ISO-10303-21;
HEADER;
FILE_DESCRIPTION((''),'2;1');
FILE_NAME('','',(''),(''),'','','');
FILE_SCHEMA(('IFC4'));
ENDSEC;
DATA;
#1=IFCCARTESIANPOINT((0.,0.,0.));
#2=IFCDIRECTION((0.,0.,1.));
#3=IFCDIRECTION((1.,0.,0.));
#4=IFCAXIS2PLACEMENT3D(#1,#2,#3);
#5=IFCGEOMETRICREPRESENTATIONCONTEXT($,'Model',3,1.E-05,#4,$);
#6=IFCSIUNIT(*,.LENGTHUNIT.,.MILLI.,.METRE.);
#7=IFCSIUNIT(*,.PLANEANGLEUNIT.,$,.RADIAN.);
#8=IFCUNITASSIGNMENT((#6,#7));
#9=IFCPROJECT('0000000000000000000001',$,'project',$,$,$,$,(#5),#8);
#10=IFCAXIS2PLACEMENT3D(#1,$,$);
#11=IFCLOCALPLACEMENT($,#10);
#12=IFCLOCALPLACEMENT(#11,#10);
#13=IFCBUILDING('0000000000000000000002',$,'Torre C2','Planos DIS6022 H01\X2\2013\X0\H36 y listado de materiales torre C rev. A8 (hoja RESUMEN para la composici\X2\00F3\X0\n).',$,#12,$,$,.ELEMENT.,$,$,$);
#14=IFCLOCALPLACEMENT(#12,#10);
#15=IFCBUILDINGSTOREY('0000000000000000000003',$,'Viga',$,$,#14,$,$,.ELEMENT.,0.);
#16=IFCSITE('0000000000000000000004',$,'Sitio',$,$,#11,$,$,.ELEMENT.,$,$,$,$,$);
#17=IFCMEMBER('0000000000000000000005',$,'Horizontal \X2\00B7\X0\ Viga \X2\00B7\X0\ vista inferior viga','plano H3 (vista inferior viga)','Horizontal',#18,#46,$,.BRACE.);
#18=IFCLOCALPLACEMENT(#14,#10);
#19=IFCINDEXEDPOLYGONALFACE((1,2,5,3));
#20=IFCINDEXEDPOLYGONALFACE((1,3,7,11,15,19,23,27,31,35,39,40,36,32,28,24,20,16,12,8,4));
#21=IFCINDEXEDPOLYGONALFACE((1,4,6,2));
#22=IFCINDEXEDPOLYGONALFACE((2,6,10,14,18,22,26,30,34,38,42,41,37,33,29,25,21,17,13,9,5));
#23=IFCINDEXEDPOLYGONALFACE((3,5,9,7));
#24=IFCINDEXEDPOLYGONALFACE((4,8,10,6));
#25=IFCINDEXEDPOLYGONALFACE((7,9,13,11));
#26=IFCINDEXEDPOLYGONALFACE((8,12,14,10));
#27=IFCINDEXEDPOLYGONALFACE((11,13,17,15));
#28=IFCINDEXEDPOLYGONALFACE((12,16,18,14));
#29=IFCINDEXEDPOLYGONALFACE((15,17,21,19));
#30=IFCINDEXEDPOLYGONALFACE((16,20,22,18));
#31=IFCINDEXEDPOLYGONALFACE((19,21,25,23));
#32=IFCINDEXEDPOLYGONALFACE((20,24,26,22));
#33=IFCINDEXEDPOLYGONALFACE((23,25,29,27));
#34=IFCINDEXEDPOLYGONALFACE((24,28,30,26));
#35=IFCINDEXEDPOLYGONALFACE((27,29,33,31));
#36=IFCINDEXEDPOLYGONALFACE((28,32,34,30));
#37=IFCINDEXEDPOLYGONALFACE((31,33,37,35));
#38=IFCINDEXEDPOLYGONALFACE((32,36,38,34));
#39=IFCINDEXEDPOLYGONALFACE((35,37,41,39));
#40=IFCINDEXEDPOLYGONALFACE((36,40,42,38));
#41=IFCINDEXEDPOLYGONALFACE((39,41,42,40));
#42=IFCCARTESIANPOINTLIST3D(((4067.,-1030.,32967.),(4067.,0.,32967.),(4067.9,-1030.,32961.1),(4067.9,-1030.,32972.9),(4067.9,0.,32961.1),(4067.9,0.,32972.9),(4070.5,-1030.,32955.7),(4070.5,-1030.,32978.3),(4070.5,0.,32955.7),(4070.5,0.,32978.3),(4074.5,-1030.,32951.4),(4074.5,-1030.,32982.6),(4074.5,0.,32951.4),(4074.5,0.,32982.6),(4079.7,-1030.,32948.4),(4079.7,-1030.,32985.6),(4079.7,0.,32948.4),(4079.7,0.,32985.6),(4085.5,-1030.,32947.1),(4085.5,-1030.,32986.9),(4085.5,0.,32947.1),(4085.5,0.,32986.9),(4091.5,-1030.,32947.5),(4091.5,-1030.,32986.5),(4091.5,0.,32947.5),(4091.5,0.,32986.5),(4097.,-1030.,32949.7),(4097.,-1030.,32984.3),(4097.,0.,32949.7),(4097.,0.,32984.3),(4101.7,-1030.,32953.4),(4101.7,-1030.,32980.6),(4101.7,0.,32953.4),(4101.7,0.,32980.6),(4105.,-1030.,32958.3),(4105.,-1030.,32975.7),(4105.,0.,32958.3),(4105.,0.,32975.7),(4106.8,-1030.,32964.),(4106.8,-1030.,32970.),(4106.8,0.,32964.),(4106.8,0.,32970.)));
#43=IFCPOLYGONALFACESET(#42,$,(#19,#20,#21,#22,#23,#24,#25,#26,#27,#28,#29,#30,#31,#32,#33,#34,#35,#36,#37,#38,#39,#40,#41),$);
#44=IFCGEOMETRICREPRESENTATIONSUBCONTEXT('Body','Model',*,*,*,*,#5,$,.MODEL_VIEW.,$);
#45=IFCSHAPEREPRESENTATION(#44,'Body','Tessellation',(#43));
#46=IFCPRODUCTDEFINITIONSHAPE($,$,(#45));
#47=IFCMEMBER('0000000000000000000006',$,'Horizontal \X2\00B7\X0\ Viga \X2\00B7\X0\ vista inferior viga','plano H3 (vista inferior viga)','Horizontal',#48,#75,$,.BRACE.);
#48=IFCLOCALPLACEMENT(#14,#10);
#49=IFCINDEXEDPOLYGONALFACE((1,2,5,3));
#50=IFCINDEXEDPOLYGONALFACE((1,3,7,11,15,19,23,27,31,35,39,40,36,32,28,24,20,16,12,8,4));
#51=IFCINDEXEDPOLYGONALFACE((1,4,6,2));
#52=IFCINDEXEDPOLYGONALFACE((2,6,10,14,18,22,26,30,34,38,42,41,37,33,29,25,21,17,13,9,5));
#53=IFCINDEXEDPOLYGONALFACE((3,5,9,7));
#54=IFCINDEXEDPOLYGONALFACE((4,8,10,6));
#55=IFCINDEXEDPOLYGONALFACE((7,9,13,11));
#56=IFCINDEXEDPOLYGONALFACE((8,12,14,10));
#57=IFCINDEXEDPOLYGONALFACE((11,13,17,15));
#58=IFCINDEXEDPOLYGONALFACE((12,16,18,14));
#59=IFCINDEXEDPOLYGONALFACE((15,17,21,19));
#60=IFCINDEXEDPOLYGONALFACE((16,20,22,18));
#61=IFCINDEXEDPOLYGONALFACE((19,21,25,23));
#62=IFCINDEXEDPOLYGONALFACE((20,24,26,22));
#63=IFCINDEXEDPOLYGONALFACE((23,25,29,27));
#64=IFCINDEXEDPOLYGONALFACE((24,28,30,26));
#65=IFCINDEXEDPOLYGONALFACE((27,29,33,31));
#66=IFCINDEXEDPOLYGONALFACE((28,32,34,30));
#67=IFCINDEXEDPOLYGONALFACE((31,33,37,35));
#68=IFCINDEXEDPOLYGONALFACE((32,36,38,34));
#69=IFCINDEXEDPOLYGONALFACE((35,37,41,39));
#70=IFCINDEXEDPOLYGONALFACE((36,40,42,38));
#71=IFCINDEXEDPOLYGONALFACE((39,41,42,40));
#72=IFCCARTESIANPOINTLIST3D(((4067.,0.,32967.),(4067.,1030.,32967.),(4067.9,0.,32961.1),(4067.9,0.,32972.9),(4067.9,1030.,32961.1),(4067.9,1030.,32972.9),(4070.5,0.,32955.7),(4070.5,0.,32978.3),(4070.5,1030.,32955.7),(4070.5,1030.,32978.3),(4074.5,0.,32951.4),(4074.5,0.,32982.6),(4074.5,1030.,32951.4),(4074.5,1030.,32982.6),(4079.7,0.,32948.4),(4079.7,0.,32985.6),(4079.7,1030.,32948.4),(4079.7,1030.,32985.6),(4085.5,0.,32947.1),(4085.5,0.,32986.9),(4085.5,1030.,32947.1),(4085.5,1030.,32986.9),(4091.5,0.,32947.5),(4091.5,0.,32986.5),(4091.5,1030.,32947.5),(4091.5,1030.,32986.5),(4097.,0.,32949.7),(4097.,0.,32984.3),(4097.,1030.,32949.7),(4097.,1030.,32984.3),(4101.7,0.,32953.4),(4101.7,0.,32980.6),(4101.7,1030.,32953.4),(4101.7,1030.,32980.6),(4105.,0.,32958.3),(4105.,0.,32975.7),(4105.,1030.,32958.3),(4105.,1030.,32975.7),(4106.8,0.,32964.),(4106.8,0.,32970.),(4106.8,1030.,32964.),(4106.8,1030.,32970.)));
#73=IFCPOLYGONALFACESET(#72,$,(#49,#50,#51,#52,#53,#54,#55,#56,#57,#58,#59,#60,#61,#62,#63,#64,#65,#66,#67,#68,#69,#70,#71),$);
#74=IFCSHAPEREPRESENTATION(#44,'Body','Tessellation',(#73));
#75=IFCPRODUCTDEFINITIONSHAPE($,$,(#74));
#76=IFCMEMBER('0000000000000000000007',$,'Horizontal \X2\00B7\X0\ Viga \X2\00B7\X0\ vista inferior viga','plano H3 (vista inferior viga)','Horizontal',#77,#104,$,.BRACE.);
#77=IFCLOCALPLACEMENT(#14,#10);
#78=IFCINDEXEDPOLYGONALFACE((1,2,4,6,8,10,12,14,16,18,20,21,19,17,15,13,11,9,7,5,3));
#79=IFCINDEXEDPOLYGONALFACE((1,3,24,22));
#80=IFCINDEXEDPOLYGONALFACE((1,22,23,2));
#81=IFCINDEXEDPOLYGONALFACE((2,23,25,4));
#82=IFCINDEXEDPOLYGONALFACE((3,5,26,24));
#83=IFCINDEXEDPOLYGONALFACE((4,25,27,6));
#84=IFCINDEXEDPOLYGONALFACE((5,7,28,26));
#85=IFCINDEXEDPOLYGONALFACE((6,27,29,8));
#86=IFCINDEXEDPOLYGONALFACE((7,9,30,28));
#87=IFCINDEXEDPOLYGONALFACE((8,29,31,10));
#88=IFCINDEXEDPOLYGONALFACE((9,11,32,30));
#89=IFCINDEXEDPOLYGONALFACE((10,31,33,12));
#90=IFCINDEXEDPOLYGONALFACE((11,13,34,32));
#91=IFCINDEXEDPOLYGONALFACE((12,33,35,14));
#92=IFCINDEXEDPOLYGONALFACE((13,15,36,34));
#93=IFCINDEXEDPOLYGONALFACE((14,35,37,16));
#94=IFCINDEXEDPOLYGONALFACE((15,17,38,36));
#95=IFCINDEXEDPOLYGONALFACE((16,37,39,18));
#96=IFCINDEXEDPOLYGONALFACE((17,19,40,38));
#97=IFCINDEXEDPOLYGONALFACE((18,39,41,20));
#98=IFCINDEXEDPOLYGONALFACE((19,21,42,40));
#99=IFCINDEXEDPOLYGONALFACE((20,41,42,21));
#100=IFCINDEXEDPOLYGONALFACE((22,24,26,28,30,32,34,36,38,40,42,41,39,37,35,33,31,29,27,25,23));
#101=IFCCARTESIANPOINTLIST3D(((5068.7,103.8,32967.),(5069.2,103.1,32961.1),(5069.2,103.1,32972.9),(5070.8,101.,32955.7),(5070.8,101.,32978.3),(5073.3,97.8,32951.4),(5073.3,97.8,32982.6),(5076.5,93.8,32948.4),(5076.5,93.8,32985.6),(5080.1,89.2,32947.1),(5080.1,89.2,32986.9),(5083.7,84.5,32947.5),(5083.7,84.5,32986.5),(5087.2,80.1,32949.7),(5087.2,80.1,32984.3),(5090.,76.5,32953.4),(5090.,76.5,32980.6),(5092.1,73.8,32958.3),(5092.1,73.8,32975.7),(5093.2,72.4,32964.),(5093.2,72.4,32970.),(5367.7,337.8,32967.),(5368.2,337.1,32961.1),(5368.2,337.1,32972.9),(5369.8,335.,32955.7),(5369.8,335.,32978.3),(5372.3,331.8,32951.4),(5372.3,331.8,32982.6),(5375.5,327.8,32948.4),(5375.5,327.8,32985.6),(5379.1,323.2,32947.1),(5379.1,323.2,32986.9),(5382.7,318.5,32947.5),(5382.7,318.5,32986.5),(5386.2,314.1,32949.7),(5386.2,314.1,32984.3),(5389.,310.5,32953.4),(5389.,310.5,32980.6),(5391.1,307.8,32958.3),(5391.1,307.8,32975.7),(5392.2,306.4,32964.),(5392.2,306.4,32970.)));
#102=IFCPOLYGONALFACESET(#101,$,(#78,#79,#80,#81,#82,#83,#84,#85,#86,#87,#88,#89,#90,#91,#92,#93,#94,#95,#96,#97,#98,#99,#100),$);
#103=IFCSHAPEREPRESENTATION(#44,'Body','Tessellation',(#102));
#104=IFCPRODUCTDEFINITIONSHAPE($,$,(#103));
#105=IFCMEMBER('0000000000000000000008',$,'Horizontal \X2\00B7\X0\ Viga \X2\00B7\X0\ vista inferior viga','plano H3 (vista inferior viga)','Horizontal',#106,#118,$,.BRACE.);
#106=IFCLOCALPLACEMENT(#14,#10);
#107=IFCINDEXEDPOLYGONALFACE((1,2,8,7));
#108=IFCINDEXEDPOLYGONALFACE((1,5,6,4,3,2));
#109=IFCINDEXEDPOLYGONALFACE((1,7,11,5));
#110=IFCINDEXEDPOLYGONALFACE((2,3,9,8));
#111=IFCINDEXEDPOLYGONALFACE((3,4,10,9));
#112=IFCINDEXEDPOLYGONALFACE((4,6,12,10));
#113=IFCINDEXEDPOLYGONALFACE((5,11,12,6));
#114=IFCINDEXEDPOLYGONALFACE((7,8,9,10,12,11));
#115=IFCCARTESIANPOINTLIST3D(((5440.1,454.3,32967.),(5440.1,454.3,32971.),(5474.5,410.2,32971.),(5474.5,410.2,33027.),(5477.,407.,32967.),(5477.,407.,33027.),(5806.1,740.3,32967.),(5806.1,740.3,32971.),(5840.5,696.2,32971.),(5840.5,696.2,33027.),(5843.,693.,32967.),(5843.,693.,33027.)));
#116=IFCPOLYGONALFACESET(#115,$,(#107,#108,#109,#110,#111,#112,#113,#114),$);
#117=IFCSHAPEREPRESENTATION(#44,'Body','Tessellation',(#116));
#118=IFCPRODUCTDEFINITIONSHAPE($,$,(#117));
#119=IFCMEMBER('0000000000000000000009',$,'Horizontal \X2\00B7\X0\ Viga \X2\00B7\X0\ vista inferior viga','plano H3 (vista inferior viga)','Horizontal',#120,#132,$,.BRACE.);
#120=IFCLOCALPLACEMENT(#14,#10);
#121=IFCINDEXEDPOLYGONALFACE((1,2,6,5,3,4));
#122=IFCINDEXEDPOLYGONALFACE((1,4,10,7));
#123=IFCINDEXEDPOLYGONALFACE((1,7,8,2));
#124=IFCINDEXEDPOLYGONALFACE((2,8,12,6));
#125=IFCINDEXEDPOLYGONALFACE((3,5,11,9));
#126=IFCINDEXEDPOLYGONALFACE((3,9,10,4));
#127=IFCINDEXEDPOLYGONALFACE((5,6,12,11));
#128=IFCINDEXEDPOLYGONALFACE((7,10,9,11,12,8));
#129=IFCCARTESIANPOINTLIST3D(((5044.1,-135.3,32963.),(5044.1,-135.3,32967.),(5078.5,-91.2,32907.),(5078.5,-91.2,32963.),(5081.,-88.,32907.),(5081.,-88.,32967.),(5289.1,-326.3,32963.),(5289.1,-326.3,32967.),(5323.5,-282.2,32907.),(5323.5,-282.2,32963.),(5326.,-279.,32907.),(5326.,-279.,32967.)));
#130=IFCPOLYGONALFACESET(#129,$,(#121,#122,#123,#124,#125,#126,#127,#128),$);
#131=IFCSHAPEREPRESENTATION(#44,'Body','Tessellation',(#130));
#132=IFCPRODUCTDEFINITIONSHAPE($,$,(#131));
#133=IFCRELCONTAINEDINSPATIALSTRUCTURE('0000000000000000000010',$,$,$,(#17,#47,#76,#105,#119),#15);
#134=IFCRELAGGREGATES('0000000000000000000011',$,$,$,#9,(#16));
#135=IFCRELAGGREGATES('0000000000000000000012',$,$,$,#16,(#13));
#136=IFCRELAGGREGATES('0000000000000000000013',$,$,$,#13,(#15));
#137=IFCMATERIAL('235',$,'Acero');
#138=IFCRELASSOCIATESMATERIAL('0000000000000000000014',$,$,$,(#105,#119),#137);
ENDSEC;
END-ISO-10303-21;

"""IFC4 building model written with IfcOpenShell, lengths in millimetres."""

from ifc_helpers import new_model, si_unit, frame, frame_2d, origin, origin_with_axes, place, context, subcontext, project, spatial, circle, l_section, extrude, material, element, save


model = new_model("IFC4")

# Units and contexts
model_context = context("Model", 3, precision=1e-05, world=origin_with_axes())
body_context = subcontext(model_context, "Body", "Model", "MODEL_VIEW")
ifc_project = project(units=[si_unit("LENGTHUNIT", "METRE", prefix="MILLI"), si_unit("PLANEANGLEUNIT", "RADIAN")], contexts=[model_context])

# Site, building, storey
site_placement = place(None, origin())
site = spatial("IfcSite", under=ifc_project, at=site_placement, Name="Sitio", CompositionType="ELEMENT")
building_placement = place(site_placement, origin())
building = spatial("IfcBuilding", under=site, at=building_placement, Name="Torre C2", Description="Planos DIS6022 H01–H36 y listado de materiales torre C rev. A8 (hoja RESUMEN para la composición).", CompositionType="ELEMENT")
storey_placement = place(building_placement, origin())
storey = spatial("IfcBuildingStorey", under=building, at=storey_placement, Name="Viga", CompositionType="ELEMENT", Elevation=0.0)

# Members
ifc_material_1 = material(Name="235", Category="Acero")
for number, where, z_axis, x_axis, name in (
    (1, (4087.0, 0.0, 32967.0), (0.0, -1.0, 0.0), (-1.0, 0.0, 0.0), "Horizontal · Viga · vista inferior viga"),
    (2, (4087.0, 0.0, 32967.0), (0.0, 1.0, 0.0), (-1.0, 0.0, 0.0), "Horizontal · Viga · vista inferior viga"),
):
    element("IfcMember", number, at=place(storey_placement, frame(where, z_axis=z_axis, x_axis=x_axis)), inside=storey, Name=name, Description="plano H3 (vista inferior viga)", ObjectType="Horizontal", PredefinedType="BRACE", context=body_context, shape_type="SweptSolid", body=[
        extrude(circle(Radius=20.0), None, (0.0, 0.0, 1.0), 1030.0),
    ])
member_1_placement = place(storey_placement, frame((5081.0, 88.0, 32967.0), z_axis=(0.787505, 0.616308, 0.0), x_axis=(-0.616308, 0.787505, 0.0)))
element("IfcMember", 3, at=member_1_placement, inside=storey, Name="Horizontal · Viga · vista inferior viga", Description="plano H3 (vista inferior viga)", ObjectType="Horizontal", PredefinedType="BRACE", context=body_context, shape_type="SweptSolid", body=[
    extrude(circle(Radius=20.0), None, (0.0, 0.0, 1.0), 379.7),
])
member_2_placement = place(storey_placement, frame((5477.0, 407.0, 32967.0), z_axis=(0.787959, 0.615728, 0.0), x_axis=(-0.615728, 0.787959, 0.0)))
element("IfcMember", 4, at=member_2_placement, inside=storey, material=ifc_material_1, Name="Horizontal · Viga · vista inferior viga", Description="plano H3 (vista inferior viga)", ObjectType="Horizontal", PredefinedType="BRACE", context=body_context, shape_type="SweptSolid", body=[
    extrude(l_section(Depth=60.0, Width=60.0, Thickness=4.0, at=frame_2d((30.0, 30.0))), None, (0.0, 0.0, 1.0), 464.5),
])
member_3_placement = place(storey_placement, frame((5081.0, -88.0, 32967.0), z_axis=(0.788658, -0.614832, 0.0), x_axis=(-0.614832, -0.788658, 0.0)))
element("IfcMember", 5, at=member_3_placement, inside=storey, material=ifc_material_1, Name="Horizontal · Viga · vista inferior viga", Description="plano H3 (vista inferior viga)", ObjectType="Horizontal", PredefinedType="BRACE", context=body_context, shape_type="SweptSolid", body=[
    extrude(l_section(Depth=60.0, Width=60.0, Thickness=4.0, at=frame_2d((30.0, 30.0))), None, (0.0, 0.0, 1.0), 310.7),
])

save(model, "model.ifc")
